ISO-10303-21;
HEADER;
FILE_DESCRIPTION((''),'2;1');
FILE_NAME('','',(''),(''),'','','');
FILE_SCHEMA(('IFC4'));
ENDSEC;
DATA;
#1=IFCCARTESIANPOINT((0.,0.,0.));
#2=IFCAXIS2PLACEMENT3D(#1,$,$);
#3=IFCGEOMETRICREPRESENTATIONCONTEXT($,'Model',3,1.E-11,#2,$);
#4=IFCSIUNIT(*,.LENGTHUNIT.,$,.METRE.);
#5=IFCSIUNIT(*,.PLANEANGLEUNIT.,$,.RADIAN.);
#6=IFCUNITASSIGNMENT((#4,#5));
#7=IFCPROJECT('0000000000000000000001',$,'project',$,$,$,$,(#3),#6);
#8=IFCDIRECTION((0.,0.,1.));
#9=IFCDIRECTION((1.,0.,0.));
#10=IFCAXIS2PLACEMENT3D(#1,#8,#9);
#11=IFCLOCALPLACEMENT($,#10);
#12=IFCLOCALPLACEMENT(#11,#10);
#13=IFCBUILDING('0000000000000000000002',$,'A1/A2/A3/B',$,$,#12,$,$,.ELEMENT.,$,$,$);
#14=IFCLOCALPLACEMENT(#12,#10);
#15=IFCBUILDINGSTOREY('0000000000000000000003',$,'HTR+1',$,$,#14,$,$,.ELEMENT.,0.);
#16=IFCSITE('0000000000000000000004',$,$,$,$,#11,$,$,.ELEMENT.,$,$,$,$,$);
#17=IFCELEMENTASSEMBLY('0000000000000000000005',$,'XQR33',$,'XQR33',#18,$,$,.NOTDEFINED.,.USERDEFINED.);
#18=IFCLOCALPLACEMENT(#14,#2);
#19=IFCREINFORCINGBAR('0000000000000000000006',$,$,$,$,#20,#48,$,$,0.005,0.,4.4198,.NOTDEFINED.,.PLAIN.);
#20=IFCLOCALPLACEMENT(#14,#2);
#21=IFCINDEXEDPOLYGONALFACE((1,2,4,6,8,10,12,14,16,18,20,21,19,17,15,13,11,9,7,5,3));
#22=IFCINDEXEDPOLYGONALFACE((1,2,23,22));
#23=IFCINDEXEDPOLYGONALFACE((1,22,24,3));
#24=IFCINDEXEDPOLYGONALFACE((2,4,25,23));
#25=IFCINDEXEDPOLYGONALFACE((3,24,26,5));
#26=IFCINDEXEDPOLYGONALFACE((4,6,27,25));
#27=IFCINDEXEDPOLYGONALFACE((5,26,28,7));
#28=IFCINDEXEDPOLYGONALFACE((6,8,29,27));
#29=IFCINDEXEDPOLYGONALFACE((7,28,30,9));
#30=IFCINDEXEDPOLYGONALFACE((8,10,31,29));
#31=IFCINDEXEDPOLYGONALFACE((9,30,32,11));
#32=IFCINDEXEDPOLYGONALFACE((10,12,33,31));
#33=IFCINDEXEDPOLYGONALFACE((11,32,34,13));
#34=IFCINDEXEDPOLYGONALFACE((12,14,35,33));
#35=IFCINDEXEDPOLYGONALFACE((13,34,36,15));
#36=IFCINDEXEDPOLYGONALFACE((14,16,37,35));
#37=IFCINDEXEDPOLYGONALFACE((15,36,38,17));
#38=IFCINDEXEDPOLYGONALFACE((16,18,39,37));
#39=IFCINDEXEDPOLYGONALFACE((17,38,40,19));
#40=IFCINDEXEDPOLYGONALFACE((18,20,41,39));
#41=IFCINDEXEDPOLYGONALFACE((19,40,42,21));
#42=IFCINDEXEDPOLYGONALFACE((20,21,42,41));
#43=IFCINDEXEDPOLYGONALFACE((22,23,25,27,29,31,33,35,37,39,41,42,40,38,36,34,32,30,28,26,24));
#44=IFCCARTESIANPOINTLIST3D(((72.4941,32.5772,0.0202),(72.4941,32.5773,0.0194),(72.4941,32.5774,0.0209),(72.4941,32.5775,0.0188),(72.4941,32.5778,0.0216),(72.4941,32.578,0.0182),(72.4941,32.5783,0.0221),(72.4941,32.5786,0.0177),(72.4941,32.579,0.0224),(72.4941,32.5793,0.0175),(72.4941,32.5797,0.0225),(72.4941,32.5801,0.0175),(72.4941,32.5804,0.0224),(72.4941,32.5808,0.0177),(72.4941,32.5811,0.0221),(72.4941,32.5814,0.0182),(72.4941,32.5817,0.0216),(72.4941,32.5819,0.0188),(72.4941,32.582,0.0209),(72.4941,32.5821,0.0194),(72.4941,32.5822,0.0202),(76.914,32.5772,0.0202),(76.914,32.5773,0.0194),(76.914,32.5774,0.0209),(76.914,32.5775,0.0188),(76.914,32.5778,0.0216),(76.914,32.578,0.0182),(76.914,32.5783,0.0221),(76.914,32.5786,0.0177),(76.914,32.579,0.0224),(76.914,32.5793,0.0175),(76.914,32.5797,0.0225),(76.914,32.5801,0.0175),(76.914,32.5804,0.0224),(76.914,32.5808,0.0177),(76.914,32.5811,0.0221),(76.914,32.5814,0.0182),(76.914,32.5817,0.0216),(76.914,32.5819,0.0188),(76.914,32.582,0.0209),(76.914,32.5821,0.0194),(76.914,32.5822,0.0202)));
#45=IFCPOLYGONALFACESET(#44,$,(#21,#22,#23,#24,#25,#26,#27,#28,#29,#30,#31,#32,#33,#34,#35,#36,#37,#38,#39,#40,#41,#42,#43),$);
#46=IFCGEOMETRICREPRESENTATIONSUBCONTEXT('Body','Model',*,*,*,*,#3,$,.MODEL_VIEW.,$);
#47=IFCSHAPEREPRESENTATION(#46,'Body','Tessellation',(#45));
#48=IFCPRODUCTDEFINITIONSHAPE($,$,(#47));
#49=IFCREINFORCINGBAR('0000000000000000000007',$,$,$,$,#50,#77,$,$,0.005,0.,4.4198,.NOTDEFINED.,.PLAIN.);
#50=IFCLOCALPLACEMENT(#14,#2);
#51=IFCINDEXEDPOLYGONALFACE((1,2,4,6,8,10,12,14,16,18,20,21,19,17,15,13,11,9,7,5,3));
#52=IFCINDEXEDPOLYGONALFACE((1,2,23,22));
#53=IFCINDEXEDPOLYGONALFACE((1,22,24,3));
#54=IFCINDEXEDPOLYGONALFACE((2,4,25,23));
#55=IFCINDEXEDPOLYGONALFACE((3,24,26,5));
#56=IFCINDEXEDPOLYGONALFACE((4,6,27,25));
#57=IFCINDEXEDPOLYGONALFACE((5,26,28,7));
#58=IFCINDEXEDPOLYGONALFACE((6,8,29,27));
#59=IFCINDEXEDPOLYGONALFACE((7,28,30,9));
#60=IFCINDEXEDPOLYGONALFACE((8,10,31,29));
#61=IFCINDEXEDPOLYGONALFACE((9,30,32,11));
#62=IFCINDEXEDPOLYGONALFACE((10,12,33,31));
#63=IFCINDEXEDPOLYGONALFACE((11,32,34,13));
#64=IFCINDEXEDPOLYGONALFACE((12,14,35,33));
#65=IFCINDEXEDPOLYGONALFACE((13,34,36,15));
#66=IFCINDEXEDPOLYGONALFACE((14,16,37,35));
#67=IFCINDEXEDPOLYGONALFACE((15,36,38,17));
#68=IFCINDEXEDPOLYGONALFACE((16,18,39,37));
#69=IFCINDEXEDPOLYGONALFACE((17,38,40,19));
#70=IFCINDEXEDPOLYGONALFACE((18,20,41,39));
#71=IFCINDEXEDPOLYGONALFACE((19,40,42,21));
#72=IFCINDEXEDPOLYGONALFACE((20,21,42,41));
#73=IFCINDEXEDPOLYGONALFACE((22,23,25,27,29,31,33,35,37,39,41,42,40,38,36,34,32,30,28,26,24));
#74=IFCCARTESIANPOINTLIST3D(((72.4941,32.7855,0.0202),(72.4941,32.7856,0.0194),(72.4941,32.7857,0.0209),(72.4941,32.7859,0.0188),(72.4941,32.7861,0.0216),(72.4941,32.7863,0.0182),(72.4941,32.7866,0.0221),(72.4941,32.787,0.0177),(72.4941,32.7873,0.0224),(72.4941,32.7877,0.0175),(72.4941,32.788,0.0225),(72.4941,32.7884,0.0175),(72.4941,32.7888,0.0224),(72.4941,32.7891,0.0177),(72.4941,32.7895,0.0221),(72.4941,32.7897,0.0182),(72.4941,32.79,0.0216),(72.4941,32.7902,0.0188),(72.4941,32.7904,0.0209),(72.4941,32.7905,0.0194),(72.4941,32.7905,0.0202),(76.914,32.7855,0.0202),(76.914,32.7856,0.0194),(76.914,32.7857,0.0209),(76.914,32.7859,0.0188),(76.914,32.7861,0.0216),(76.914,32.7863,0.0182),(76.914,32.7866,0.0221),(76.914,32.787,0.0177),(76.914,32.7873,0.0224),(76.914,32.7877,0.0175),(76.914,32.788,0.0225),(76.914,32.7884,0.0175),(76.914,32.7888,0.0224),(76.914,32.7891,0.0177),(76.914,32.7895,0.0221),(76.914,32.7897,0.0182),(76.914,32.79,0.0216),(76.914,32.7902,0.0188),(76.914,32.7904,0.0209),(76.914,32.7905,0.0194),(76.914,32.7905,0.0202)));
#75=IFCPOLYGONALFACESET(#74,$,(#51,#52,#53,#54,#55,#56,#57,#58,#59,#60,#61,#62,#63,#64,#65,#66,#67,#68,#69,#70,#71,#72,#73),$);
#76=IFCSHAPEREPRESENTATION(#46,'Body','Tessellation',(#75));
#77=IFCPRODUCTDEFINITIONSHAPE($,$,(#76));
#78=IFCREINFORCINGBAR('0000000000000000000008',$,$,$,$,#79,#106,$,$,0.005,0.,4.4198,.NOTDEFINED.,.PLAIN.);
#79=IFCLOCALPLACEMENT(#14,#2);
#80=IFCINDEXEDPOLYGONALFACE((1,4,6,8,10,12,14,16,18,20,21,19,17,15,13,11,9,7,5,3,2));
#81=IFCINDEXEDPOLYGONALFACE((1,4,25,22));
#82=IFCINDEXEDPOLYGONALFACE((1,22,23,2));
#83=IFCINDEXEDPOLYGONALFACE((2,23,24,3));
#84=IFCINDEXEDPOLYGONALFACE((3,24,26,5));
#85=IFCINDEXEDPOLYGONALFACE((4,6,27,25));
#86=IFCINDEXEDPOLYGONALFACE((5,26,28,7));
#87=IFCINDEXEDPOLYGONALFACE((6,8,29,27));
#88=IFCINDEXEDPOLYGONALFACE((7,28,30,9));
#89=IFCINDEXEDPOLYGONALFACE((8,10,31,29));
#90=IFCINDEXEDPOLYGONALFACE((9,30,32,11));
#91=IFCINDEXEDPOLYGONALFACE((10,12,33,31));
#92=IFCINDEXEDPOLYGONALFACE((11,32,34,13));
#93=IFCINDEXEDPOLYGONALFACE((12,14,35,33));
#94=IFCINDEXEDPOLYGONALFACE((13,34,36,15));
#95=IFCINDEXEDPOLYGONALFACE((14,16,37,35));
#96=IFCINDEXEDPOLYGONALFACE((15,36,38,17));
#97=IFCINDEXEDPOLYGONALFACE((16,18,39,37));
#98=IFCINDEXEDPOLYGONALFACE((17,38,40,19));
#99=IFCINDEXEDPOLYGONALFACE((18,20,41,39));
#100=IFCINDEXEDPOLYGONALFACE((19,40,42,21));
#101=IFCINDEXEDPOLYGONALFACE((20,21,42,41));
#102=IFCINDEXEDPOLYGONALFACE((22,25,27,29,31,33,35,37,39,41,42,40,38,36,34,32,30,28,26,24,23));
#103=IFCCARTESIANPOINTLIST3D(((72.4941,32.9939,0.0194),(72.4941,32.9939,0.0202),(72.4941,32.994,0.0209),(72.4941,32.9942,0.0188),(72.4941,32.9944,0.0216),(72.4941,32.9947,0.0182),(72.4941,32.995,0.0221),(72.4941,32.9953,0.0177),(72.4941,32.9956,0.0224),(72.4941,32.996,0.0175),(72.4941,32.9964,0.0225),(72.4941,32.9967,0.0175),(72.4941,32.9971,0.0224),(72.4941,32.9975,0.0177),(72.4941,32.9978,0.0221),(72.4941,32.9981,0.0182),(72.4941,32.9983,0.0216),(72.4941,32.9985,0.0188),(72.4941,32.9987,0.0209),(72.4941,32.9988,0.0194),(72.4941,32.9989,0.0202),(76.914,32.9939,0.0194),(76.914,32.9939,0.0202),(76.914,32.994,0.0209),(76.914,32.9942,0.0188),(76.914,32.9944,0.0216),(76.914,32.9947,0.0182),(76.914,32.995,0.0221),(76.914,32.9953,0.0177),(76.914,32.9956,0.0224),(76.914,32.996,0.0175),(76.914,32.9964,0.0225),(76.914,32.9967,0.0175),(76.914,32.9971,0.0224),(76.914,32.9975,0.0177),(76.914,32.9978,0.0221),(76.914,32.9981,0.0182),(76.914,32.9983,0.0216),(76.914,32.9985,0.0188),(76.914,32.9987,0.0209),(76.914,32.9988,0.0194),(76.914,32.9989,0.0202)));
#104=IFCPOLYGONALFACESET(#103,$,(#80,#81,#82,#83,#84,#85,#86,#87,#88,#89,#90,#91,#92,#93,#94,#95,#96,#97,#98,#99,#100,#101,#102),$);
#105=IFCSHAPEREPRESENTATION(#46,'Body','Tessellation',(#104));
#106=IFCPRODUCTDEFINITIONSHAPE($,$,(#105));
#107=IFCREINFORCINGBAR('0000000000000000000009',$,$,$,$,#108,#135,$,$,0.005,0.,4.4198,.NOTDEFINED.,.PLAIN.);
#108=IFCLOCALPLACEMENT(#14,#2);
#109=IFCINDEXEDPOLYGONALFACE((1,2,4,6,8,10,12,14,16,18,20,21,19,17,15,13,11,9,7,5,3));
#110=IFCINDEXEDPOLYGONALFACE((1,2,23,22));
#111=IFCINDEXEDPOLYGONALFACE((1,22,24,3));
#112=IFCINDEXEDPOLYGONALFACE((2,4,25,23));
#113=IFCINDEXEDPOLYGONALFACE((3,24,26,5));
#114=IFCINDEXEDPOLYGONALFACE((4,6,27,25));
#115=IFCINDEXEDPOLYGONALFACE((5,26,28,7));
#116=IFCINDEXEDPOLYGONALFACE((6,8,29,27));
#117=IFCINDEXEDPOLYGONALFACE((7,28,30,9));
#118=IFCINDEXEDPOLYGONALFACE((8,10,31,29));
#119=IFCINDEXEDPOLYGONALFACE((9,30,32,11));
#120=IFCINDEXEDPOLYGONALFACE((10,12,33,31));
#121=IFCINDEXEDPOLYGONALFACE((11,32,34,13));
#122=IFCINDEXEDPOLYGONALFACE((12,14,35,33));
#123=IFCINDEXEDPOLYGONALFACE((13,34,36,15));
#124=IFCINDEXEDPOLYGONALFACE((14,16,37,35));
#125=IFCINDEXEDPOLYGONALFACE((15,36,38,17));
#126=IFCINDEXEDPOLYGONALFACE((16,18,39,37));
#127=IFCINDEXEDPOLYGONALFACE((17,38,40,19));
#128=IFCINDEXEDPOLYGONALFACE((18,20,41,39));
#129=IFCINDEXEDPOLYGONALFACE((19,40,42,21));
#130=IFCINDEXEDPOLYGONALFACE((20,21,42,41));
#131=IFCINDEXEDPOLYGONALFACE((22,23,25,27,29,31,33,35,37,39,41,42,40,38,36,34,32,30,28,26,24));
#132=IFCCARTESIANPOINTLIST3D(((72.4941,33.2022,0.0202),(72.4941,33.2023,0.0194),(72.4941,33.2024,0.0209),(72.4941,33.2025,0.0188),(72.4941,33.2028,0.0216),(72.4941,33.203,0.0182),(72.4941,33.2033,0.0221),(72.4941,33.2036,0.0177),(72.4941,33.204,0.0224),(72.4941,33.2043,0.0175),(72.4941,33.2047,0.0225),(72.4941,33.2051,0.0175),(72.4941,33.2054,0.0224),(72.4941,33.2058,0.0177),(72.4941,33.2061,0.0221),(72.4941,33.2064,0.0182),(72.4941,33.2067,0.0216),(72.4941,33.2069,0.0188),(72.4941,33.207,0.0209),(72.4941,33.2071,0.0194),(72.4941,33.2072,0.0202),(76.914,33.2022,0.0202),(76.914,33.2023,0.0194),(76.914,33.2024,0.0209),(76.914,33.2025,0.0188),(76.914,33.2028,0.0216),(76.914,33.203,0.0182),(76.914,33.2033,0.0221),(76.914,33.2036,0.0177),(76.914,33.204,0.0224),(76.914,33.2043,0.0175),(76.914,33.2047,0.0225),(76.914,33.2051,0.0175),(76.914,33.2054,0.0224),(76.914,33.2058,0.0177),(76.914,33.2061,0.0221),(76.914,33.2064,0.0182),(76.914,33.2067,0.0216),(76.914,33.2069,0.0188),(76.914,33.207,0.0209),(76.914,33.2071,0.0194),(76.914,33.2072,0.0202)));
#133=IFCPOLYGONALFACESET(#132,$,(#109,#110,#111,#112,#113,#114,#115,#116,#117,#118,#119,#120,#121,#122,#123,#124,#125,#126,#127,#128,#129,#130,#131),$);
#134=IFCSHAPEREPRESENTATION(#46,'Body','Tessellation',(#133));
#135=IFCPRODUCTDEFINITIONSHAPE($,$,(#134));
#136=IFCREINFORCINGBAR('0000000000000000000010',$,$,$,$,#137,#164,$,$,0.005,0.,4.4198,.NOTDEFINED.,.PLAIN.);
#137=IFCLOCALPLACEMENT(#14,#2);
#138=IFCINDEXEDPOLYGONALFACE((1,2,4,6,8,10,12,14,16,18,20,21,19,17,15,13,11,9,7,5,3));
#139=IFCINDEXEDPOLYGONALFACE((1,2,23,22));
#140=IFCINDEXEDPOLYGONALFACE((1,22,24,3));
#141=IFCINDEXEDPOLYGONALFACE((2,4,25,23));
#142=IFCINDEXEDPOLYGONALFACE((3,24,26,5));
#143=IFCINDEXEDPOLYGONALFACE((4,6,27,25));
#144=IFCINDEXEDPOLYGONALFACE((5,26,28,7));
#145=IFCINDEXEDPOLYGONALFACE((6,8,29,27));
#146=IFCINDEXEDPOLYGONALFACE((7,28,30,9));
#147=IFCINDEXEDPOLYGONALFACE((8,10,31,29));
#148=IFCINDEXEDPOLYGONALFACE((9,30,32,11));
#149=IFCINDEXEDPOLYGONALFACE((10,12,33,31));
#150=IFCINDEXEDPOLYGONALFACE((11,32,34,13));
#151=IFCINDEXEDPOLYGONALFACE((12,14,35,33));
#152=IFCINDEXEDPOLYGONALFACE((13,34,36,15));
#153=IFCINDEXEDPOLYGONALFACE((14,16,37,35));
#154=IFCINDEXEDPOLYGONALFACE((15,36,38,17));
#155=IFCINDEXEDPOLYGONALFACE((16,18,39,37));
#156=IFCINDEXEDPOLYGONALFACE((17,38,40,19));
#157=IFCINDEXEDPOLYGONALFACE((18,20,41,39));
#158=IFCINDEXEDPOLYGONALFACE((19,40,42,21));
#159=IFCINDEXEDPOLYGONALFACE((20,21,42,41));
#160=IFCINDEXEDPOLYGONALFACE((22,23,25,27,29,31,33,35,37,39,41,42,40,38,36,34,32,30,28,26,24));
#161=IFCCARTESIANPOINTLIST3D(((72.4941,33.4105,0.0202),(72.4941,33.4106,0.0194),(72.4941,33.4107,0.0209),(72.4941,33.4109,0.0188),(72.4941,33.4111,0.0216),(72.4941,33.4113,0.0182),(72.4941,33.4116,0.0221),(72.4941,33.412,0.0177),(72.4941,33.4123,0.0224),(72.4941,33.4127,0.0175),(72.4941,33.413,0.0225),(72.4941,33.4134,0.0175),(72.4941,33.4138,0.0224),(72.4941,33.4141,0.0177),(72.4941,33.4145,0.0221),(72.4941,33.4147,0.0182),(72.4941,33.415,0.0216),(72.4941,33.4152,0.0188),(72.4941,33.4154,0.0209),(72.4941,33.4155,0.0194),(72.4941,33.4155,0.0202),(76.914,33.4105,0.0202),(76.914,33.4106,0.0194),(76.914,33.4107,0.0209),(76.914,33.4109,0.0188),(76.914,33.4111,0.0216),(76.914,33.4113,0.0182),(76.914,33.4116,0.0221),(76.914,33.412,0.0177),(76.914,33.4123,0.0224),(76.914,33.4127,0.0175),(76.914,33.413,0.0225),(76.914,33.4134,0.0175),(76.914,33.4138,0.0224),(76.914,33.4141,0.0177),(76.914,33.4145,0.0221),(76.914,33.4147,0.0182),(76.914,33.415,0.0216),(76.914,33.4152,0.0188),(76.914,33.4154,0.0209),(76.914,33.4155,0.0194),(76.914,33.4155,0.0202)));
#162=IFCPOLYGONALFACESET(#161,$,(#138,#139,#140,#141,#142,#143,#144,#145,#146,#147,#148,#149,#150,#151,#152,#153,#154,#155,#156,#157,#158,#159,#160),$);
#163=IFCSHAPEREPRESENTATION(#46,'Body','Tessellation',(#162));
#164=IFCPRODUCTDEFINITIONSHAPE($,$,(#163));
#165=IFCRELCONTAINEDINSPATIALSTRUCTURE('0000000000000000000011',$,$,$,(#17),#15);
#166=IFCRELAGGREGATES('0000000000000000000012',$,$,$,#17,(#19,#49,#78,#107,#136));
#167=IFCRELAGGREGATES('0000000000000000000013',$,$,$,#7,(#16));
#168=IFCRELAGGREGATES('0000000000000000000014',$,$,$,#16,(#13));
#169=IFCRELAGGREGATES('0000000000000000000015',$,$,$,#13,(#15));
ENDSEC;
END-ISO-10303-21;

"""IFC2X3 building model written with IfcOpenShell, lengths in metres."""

from ifc_helpers import new_model, entity, si_unit, origin, origin_with_axes, place, context, subcontext, project, spatial, shape, element, aggregate, save


model = new_model("IFC2X3")

# Units and contexts
model_context = context("Model", 3, precision=1e-11, world=origin())
body_context = subcontext(model_context, "Body", "Model", "MODEL_VIEW")
ifc_project = project(units=[si_unit("LENGTHUNIT", "METRE"), si_unit("PLANEANGLEUNIT", "RADIAN")], contexts=[model_context])

# Site, building, storey
site_placement = place(None, origin_with_axes())
site = spatial("IfcSite", under=ifc_project, at=site_placement, CompositionType="ELEMENT")
building_placement = place(site_placement, origin_with_axes())
building = spatial("IfcBuilding", under=site, at=building_placement, Name="A1/A2/A3/B", CompositionType="ELEMENT")
storey_placement = place(building_placement, origin_with_axes())
storey = spatial("IfcBuildingStorey", under=building, at=storey_placement, Name="HTR+1", CompositionType="ELEMENT", Elevation=0.0)

# Element assembly, reinforcing bars
assembly_1_placement = place(storey_placement, origin_with_axes())
assembly_1 = element("IfcElementAssembly", 1, at=assembly_1_placement, inside=storey, Name="XQR33", ObjectType="XQR33", AssemblyPlace="NOTDEFINED", PredefinedType="USERDEFINED")
reinforcing_bar_1_placement = place(assembly_1_placement, origin_with_axes())
reinforcing_bar_1 = element("IfcReinforcingBar", 2, at=reinforcing_bar_1_placement, BarLength=4.4198, BarRole="NOTDEFINED", BarSurface="PLAIN", CrossSectionArea=0.0, NominalDiameter=0.005, shapes=[
    shape(body_context, "Body", "AdvancedSweptSolid", [entity("IfcSweptDiskSolid", entity("IfcPolyline", [entity("IfcCartesianPoint", [72.4941, 32.5797, 0.02]), entity("IfcCartesianPoint", [76.914, 32.5797, 0.02])]), 0.0025, None, 0.0, 4.4198)]),
    shape(body_context, "Body", "AdvancedSweptSolid", [entity("IfcSweptDiskSolid", entity("IfcPolyline", [entity("IfcCartesianPoint", [72.4941, 32.5797, 0.02]), entity("IfcCartesianPoint", [76.914, 32.5797, 0.02])]), 0.0025, None, 0.0, 4.4198)]),
])
reinforcing_bar_2_placement = place(assembly_1_placement, origin_with_axes())
reinforcing_bar_2 = element("IfcReinforcingBar", 3, at=reinforcing_bar_2_placement, BarLength=4.4198, BarRole="NOTDEFINED", BarSurface="PLAIN", CrossSectionArea=0.0, NominalDiameter=0.005, shapes=[
    shape(body_context, "Body", "AdvancedSweptSolid", [entity("IfcSweptDiskSolid", entity("IfcPolyline", [entity("IfcCartesianPoint", [72.4941, 32.788, 0.02]), entity("IfcCartesianPoint", [76.914, 32.788, 0.02])]), 0.0025, None, 0.0, 4.4198)]),
    shape(body_context, "Body", "AdvancedSweptSolid", [entity("IfcSweptDiskSolid", entity("IfcPolyline", [entity("IfcCartesianPoint", [72.4941, 32.788, 0.02]), entity("IfcCartesianPoint", [76.914, 32.788, 0.02])]), 0.0025, None, 0.0, 4.4198)]),
])
reinforcing_bar_3_placement = place(assembly_1_placement, origin_with_axes())
reinforcing_bar_3 = element("IfcReinforcingBar", 4, at=reinforcing_bar_3_placement, BarLength=4.4198, BarRole="NOTDEFINED", BarSurface="PLAIN", CrossSectionArea=0.0, NominalDiameter=0.005, shapes=[
    shape(body_context, "Body", "AdvancedSweptSolid", [entity("IfcSweptDiskSolid", entity("IfcPolyline", [entity("IfcCartesianPoint", [72.4941, 32.9964, 0.02]), entity("IfcCartesianPoint", [76.914, 32.9964, 0.02])]), 0.0025, None, 0.0, 4.4198)]),
    shape(body_context, "Body", "AdvancedSweptSolid", [entity("IfcSweptDiskSolid", entity("IfcPolyline", [entity("IfcCartesianPoint", [72.4941, 32.9964, 0.02]), entity("IfcCartesianPoint", [76.914, 32.9964, 0.02])]), 0.0025, None, 0.0, 4.4198)]),
])
reinforcing_bar_4_placement = place(assembly_1_placement, origin_with_axes())
reinforcing_bar_4 = element("IfcReinforcingBar", 5, at=reinforcing_bar_4_placement, BarLength=4.4198, BarRole="NOTDEFINED", BarSurface="PLAIN", CrossSectionArea=0.0, NominalDiameter=0.005, shapes=[
    shape(body_context, "Body", "AdvancedSweptSolid", [entity("IfcSweptDiskSolid", entity("IfcPolyline", [entity("IfcCartesianPoint", [72.4941, 33.2047, 0.02]), entity("IfcCartesianPoint", [76.914, 33.2047, 0.02])]), 0.0025, None, 0.0, 4.4198)]),
    shape(body_context, "Body", "AdvancedSweptSolid", [entity("IfcSweptDiskSolid", entity("IfcPolyline", [entity("IfcCartesianPoint", [72.4941, 33.2047, 0.02]), entity("IfcCartesianPoint", [76.914, 33.2047, 0.02])]), 0.0025, None, 0.0, 4.4198)]),
])
reinforcing_bar_5_placement = place(assembly_1_placement, origin_with_axes())
reinforcing_bar_5 = element("IfcReinforcingBar", 6, at=reinforcing_bar_5_placement, BarLength=4.4198, BarRole="NOTDEFINED", BarSurface="PLAIN", CrossSectionArea=0.0, NominalDiameter=0.005, shapes=[
    shape(body_context, "Body", "AdvancedSweptSolid", [entity("IfcSweptDiskSolid", entity("IfcPolyline", [entity("IfcCartesianPoint", [72.4941, 33.413, 0.02]), entity("IfcCartesianPoint", [76.914, 33.413, 0.02])]), 0.0025, None, 0.0, 4.4198)]),
    shape(body_context, "Body", "AdvancedSweptSolid", [entity("IfcSweptDiskSolid", entity("IfcPolyline", [entity("IfcCartesianPoint", [72.4941, 33.413, 0.02]), entity("IfcCartesianPoint", [76.914, 33.413, 0.02])]), 0.0025, None, 0.0, 4.4198)]),
])
aggregate(assembly_1, [reinforcing_bar_1, reinforcing_bar_2, reinforcing_bar_3, reinforcing_bar_4, reinforcing_bar_5])

save(model, "model.ifc")
